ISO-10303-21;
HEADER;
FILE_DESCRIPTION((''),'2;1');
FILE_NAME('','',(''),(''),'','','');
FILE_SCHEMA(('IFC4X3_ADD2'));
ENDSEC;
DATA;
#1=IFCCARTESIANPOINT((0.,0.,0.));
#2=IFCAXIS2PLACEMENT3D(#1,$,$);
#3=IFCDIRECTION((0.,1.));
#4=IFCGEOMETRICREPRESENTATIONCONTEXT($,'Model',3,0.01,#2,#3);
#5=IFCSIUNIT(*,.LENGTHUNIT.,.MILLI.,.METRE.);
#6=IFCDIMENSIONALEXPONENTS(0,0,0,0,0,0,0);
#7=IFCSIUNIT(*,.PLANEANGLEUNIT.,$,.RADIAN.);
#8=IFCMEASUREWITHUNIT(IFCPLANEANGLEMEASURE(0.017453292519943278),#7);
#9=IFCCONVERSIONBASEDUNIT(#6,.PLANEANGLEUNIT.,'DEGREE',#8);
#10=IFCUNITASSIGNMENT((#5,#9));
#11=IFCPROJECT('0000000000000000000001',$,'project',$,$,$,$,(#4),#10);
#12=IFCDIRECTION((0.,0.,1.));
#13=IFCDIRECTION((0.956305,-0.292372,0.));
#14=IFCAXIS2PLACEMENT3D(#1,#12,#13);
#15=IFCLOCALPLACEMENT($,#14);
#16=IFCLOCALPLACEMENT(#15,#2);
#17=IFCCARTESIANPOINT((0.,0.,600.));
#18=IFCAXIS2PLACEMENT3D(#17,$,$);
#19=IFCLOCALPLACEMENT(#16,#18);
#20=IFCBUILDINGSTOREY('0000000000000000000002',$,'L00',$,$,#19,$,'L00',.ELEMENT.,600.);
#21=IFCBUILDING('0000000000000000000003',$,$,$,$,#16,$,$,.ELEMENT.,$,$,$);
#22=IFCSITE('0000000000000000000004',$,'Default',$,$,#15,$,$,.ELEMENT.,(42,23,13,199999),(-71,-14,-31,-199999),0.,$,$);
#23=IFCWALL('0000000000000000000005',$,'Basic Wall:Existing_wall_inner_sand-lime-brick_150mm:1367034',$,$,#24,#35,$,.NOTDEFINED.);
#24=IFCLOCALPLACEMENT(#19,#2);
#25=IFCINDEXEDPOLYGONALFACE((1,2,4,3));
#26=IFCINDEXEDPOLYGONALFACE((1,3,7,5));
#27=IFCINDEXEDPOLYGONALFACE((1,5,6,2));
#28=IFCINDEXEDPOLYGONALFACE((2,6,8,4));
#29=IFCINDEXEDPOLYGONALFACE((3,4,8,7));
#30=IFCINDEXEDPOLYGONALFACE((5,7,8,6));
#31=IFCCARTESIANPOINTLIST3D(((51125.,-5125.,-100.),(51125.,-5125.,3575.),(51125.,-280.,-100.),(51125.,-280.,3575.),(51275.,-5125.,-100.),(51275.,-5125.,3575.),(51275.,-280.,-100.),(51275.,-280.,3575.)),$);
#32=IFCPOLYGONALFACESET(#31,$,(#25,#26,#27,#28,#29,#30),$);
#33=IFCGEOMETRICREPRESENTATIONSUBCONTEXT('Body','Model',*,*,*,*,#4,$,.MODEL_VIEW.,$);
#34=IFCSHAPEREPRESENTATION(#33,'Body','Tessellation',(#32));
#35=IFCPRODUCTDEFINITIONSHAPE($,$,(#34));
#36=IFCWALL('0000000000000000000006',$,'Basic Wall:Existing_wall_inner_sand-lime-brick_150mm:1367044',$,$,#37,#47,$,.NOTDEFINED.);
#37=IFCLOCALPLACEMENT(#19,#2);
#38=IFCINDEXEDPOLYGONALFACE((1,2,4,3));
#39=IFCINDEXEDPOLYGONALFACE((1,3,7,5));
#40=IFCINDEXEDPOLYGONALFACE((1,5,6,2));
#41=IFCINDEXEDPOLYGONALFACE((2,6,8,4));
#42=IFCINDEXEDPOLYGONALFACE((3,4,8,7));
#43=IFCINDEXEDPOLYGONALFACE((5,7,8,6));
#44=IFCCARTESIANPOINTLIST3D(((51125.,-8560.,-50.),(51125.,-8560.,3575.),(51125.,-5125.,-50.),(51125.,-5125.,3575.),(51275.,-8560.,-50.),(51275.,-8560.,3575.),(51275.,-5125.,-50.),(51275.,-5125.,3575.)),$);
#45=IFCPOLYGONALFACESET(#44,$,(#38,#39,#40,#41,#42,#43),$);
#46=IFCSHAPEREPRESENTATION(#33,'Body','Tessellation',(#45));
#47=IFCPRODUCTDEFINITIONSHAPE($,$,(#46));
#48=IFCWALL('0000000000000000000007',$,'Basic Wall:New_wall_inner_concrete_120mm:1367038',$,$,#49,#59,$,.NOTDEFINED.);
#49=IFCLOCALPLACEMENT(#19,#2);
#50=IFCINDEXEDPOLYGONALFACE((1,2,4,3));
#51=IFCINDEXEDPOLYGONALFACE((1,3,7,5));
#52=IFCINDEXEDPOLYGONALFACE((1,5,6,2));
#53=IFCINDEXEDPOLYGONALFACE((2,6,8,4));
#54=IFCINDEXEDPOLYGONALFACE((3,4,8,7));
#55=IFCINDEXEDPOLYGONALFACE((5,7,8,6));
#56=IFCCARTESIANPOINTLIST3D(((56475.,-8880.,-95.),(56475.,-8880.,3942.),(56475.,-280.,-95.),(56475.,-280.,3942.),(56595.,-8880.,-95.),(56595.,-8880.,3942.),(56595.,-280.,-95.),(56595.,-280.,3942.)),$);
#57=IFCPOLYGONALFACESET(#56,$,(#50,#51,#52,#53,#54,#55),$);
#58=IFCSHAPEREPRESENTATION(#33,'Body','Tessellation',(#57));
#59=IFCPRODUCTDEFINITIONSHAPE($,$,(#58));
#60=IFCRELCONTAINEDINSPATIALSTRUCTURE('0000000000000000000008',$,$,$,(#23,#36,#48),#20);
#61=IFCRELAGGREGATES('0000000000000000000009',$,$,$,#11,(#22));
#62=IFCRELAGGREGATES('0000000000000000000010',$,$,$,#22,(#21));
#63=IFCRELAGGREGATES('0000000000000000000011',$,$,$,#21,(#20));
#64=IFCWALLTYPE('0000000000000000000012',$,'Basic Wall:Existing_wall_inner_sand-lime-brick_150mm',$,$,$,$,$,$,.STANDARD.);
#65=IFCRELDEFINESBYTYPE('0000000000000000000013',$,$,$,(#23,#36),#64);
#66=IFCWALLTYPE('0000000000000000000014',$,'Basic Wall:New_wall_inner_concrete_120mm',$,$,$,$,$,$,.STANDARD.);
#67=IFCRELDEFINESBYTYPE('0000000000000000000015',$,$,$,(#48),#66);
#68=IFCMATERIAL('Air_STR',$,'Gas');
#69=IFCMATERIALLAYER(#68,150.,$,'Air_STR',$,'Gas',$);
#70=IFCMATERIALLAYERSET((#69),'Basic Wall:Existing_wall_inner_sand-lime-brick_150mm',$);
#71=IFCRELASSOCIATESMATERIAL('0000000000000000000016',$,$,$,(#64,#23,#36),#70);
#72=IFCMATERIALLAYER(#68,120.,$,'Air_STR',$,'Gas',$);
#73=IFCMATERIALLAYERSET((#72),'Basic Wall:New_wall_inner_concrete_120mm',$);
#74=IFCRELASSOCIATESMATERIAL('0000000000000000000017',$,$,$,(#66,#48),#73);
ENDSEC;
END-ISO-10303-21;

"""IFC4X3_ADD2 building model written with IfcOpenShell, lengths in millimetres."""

from ifc_helpers import new_model, entity, si_unit, converted_unit, direction, frame, frame_2d, origin, place, context, subcontext, project, spatial, rectangle, extrude, material, layer, layer_set, type_object, element, save


model = new_model("IFC4X3_ADD2")

# Units and contexts
model_context = context("Model", 3, precision=0.01, world=origin(), true_north=direction((0.0, 1.0)))
body_context = subcontext(model_context, "Body", "Model", "MODEL_VIEW")
ifc_project = project(units=[si_unit("LENGTHUNIT", "METRE", prefix="MILLI"), converted_unit("PLANEANGLEUNIT", "DEGREE", entity("IfcPlaneAngleMeasure", 0.017453292519943278), si_unit("PLANEANGLEUNIT", "RADIAN"), dimensions=[0, 0, 0, 0, 0, 0, 0])], contexts=[model_context])

# Site, building, storey
site_placement = place(None, frame((0.0, 0.0, 0.0), z_axis=(0.0, 0.0, 1.0), x_axis=(0.956305, -0.292372, 0.0)))
site = spatial("IfcSite", under=ifc_project, at=site_placement, Name="Default", CompositionType="ELEMENT", RefLatitude=(42, 23, 13, 199999), RefLongitude=(-71, -14, -31, -199999), RefElevation=0.0)
building_placement = place(site_placement, origin())
building = spatial("IfcBuilding", under=site, at=building_placement, CompositionType="ELEMENT")
storey_placement = place(building_placement, frame((0.0, 0.0, 600.0)))
storey = spatial("IfcBuildingStorey", under=building, at=storey_placement, Name="L00", LongName="L00", CompositionType="ELEMENT", Elevation=600.0)

# Walls
ifc_material_1 = material(Name="Air_STR", Category="Gas")
ifc_layer_1 = layer(ifc_material_1, 150.0, Name="Air_STR", Category="Gas")
ifc_layer_set_1 = layer_set([ifc_layer_1], Name="Basic Wall:Existing_wall_inner_sand-lime-brick_150mm")
wall_type_1 = type_object("IfcWallType", Name="Basic Wall:Existing_wall_inner_sand-lime-brick_150mm", PredefinedType="STANDARD", material=ifc_layer_set_1)
wall_1_placement = place(storey_placement, frame((51200.0, -280.0, -100.0), z_axis=(0.0, 0.0, 1.0), x_axis=(0.0, -1.0, 0.0)))
element("IfcWall", 1, at=wall_1_placement, inside=storey, type_object=wall_type_1, material=ifc_layer_set_1, Name="Basic Wall:Existing_wall_inner_sand-lime-brick_150mm:1367034", PredefinedType="NOTDEFINED", context=body_context, shape_type="SweptSolid", body=[
    extrude(rectangle(XDim=4845.0, YDim=150.0, at=frame_2d((2422.5, 0.0), x_axis=(-1.0, 0.0))), origin(), (0.0, 0.0, 1.0), 3675.0),
])
wall_2_placement = place(storey_placement, frame((51200.0, -5125.0, -50.0), z_axis=(0.0, 0.0, 1.0), x_axis=(0.0, -1.0, 0.0)))
element("IfcWall", 2, at=wall_2_placement, inside=storey, type_object=wall_type_1, material=ifc_layer_set_1, Name="Basic Wall:Existing_wall_inner_sand-lime-brick_150mm:1367044", PredefinedType="NOTDEFINED", context=body_context, shape_type="SweptSolid", body=[
    extrude(rectangle(XDim=3435.0, YDim=150.0, at=frame_2d((1717.5, 0.0), x_axis=(-1.0, 0.0))), origin(), (0.0, 0.0, 1.0), 3625.0),
])
ifc_layer_2 = layer(ifc_material_1, 120.0, Name="Air_STR", Category="Gas")
ifc_layer_set_2 = layer_set([ifc_layer_2], Name="Basic Wall:New_wall_inner_concrete_120mm")
wall_type_2 = type_object("IfcWallType", Name="Basic Wall:New_wall_inner_concrete_120mm", PredefinedType="STANDARD", material=ifc_layer_set_2)
wall_3_placement = place(storey_placement, frame((56535.0, -8880.0, -95.0), z_axis=(0.0, 0.0, 1.0), x_axis=(0.0, 1.0, 0.0)))
element("IfcWall", 3, at=wall_3_placement, inside=storey, type_object=wall_type_2, material=ifc_layer_set_2, Name="Basic Wall:New_wall_inner_concrete_120mm:1367038", PredefinedType="NOTDEFINED", context=body_context, shape_type="SweptSolid", body=[
    extrude(rectangle(XDim=8600.0, YDim=120.0, at=frame_2d((4300.0, 0.0), x_axis=(-1.0, 0.0))), origin(), (0.0, 0.0, 1.0), 4037.0),
])

save(model, "model.ifc")
